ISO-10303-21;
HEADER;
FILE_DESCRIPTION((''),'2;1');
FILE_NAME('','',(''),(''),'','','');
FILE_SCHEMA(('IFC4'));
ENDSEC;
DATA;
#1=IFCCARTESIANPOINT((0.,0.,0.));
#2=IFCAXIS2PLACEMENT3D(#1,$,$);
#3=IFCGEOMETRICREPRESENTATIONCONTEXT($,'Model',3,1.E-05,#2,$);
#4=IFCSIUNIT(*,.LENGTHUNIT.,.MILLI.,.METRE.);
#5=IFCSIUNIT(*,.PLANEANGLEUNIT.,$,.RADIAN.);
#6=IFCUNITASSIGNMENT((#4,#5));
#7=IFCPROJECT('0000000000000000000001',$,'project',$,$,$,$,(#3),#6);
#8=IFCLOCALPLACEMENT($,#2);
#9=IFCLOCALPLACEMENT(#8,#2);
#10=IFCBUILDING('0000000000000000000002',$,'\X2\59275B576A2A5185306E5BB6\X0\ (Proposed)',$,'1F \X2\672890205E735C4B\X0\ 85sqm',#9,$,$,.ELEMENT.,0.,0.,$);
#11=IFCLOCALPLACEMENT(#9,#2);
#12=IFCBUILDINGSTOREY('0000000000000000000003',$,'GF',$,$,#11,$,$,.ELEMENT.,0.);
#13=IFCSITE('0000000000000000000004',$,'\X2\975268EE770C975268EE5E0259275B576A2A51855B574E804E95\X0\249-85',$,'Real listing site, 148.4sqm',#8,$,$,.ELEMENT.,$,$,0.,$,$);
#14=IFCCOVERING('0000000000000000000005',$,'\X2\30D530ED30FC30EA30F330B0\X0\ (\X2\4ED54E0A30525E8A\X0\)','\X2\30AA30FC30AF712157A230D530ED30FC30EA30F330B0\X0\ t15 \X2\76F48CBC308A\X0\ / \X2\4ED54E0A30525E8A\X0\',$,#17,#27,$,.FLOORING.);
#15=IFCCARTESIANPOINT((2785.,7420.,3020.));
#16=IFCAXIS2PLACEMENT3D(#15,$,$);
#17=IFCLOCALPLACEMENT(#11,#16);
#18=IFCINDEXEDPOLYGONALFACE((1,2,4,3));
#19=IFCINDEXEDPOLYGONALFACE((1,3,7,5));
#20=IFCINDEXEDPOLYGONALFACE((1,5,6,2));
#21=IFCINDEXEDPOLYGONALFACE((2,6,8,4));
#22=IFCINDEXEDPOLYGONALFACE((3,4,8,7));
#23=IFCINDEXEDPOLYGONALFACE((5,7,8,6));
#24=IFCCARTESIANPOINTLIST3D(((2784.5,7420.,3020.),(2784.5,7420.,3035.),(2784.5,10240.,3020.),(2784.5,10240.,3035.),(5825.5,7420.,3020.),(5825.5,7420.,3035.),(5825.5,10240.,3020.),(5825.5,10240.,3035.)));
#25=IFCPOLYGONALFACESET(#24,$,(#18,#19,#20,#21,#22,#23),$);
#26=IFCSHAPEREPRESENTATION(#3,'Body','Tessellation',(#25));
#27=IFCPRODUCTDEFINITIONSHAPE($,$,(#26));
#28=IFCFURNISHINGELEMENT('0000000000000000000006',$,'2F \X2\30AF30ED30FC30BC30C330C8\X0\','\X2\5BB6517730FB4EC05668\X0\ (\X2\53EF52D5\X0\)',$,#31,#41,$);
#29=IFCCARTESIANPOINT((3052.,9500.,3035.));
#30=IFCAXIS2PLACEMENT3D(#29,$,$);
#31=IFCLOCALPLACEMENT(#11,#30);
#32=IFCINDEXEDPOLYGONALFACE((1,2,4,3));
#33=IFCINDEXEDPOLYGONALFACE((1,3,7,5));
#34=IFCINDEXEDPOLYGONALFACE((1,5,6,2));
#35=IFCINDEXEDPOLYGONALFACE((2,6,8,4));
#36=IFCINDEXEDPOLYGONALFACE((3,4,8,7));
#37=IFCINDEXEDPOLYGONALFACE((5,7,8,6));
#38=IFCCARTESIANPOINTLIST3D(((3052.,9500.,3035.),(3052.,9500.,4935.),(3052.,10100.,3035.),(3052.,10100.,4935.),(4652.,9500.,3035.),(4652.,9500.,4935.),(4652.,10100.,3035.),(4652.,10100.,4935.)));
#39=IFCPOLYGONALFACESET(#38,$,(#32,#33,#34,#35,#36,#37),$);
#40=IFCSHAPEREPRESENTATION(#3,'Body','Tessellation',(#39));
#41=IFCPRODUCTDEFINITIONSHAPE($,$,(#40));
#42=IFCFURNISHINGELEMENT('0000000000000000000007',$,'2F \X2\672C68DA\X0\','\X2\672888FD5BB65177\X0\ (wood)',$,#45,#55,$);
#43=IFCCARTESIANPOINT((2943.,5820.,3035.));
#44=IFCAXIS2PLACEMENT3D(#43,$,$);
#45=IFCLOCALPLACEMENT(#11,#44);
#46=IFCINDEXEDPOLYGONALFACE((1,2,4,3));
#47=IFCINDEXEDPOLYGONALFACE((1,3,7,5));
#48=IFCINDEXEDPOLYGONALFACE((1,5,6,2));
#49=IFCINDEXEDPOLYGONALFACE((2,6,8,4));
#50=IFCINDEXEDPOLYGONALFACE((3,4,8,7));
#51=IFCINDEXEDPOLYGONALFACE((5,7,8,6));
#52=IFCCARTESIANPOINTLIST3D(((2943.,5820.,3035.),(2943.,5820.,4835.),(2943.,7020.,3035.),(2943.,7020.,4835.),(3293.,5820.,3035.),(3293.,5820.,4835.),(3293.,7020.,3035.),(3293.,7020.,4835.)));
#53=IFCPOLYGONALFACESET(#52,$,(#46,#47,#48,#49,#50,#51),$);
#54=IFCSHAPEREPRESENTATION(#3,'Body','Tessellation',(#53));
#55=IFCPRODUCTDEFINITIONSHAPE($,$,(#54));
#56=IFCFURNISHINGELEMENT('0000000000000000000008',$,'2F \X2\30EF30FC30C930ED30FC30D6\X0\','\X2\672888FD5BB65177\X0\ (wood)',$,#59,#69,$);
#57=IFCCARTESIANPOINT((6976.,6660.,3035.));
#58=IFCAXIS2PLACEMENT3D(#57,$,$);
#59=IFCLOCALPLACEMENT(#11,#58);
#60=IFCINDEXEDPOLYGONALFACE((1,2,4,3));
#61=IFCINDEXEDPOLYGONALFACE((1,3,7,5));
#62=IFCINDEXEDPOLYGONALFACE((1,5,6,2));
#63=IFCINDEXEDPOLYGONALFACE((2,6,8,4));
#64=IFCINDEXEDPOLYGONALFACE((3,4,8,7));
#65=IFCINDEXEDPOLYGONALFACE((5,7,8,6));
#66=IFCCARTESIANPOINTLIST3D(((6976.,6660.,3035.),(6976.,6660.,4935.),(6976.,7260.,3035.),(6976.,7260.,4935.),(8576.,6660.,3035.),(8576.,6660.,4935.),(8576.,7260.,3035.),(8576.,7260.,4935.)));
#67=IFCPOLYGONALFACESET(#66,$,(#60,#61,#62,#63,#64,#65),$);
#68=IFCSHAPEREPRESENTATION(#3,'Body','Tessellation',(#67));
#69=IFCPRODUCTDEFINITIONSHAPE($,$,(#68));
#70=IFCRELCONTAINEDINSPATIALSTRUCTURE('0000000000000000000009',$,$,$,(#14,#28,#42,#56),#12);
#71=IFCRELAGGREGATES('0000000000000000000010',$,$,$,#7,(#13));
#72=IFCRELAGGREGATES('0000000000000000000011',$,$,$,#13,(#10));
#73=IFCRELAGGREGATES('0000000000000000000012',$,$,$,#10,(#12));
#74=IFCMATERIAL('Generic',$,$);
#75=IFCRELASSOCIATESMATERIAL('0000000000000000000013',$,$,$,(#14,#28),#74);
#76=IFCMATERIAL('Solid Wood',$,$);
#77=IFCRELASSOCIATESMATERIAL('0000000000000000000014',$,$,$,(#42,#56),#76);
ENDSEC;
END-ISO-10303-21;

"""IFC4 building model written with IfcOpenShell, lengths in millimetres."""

from ifc_helpers import new_model, si_unit, frame, frame_2d, origin, place, context, project, spatial, rectangle, extrude, material, element, save


model = new_model("IFC4")

# Units and contexts
model_context = context("Model", 3, precision=1e-05, world=origin())
ifc_project = project(units=[si_unit("LENGTHUNIT", "METRE", prefix="MILLI"), si_unit("PLANEANGLEUNIT", "RADIAN")], contexts=[model_context])

# Site, building, storey
site_placement = place(None, origin())
site = spatial("IfcSite", under=ifc_project, at=site_placement, Name="青森県青森市大字横内字亀井249-85", ObjectType="Real listing site, 148.4sqm", CompositionType="ELEMENT", RefElevation=0.0)
building_placement = place(site_placement, origin())
building = spatial("IfcBuilding", under=site, at=building_placement, Name="大字横内の家 (Proposed)", ObjectType="1F 木造平屋 85sqm", CompositionType="ELEMENT", ElevationOfRefHeight=0.0, ElevationOfTerrain=0.0)
storey_placement = place(building_placement, origin())
storey = spatial("IfcBuildingStorey", under=building, at=storey_placement, Name="GF", CompositionType="ELEMENT", Elevation=0.0)

# Shared definitions
ifc_material_1 = material(Name="Solid Wood")

# Shared definitions
ifc_material_2 = material(Name="Generic")

# Covering
covering_placement = place(storey_placement, frame((2785.0, 7420.0, 3020.0)))
element("IfcCovering", 1, at=covering_placement, inside=storey, material=ifc_material_2, Name="フローリング (仕上げ床)", Description="オーク無垢フローリング t15 直貼り / 仕上げ床", PredefinedType="FLOORING", context=model_context, shape_type="SweptSolid", body=[
    extrude(rectangle(XDim=3041.0, YDim=2820.0, at=frame_2d((1520.0, 1410.0))), frame((2785.0, 7420.0, 3020.0)), (0.0, 0.0, 1.0), 15.0),
])

# Furnishing elements
furnishing_1_placement = place(storey_placement, frame((3052.0, 9500.0, 3035.0)))
element("IfcFurnishingElement", 2, at=furnishing_1_placement, inside=storey, material=ifc_material_2, Name="2F クローゼット", Description="家具・什器 (可動)", context=model_context, shape_type="SweptSolid", body=[
    extrude(rectangle(XDim=1600.0, YDim=600.0, at=frame_2d((800.0, 300.0))), frame((3052.0, 9500.0, 3035.0)), (0.0, 0.0, 1.0), 1900.0),
])
furnishing_2_placement = place(storey_placement, frame((2943.0, 5820.0, 3035.0)))
element("IfcFurnishingElement", 3, at=furnishing_2_placement, inside=storey, material=ifc_material_1, Name="2F 本棚", Description="木製家具 (wood)", context=model_context, shape_type="SweptSolid", body=[
    extrude(rectangle(XDim=350.0, YDim=1200.0, at=frame_2d((175.0, 600.0))), frame((2943.0, 5820.0, 3035.0)), (0.0, 0.0, 1.0), 1800.0),
])
furnishing_3_placement = place(storey_placement, frame((6976.0, 6660.0, 3035.0)))
element("IfcFurnishingElement", 4, at=furnishing_3_placement, inside=storey, material=ifc_material_1, Name="2F ワードローブ", Description="木製家具 (wood)", context=model_context, shape_type="SweptSolid", body=[
    extrude(rectangle(XDim=1600.0, YDim=600.0, at=frame_2d((800.0, 300.0))), frame((6976.0, 6660.0, 3035.0)), (0.0, 0.0, 1.0), 1900.0),
])

save(model, "model.ifc")
